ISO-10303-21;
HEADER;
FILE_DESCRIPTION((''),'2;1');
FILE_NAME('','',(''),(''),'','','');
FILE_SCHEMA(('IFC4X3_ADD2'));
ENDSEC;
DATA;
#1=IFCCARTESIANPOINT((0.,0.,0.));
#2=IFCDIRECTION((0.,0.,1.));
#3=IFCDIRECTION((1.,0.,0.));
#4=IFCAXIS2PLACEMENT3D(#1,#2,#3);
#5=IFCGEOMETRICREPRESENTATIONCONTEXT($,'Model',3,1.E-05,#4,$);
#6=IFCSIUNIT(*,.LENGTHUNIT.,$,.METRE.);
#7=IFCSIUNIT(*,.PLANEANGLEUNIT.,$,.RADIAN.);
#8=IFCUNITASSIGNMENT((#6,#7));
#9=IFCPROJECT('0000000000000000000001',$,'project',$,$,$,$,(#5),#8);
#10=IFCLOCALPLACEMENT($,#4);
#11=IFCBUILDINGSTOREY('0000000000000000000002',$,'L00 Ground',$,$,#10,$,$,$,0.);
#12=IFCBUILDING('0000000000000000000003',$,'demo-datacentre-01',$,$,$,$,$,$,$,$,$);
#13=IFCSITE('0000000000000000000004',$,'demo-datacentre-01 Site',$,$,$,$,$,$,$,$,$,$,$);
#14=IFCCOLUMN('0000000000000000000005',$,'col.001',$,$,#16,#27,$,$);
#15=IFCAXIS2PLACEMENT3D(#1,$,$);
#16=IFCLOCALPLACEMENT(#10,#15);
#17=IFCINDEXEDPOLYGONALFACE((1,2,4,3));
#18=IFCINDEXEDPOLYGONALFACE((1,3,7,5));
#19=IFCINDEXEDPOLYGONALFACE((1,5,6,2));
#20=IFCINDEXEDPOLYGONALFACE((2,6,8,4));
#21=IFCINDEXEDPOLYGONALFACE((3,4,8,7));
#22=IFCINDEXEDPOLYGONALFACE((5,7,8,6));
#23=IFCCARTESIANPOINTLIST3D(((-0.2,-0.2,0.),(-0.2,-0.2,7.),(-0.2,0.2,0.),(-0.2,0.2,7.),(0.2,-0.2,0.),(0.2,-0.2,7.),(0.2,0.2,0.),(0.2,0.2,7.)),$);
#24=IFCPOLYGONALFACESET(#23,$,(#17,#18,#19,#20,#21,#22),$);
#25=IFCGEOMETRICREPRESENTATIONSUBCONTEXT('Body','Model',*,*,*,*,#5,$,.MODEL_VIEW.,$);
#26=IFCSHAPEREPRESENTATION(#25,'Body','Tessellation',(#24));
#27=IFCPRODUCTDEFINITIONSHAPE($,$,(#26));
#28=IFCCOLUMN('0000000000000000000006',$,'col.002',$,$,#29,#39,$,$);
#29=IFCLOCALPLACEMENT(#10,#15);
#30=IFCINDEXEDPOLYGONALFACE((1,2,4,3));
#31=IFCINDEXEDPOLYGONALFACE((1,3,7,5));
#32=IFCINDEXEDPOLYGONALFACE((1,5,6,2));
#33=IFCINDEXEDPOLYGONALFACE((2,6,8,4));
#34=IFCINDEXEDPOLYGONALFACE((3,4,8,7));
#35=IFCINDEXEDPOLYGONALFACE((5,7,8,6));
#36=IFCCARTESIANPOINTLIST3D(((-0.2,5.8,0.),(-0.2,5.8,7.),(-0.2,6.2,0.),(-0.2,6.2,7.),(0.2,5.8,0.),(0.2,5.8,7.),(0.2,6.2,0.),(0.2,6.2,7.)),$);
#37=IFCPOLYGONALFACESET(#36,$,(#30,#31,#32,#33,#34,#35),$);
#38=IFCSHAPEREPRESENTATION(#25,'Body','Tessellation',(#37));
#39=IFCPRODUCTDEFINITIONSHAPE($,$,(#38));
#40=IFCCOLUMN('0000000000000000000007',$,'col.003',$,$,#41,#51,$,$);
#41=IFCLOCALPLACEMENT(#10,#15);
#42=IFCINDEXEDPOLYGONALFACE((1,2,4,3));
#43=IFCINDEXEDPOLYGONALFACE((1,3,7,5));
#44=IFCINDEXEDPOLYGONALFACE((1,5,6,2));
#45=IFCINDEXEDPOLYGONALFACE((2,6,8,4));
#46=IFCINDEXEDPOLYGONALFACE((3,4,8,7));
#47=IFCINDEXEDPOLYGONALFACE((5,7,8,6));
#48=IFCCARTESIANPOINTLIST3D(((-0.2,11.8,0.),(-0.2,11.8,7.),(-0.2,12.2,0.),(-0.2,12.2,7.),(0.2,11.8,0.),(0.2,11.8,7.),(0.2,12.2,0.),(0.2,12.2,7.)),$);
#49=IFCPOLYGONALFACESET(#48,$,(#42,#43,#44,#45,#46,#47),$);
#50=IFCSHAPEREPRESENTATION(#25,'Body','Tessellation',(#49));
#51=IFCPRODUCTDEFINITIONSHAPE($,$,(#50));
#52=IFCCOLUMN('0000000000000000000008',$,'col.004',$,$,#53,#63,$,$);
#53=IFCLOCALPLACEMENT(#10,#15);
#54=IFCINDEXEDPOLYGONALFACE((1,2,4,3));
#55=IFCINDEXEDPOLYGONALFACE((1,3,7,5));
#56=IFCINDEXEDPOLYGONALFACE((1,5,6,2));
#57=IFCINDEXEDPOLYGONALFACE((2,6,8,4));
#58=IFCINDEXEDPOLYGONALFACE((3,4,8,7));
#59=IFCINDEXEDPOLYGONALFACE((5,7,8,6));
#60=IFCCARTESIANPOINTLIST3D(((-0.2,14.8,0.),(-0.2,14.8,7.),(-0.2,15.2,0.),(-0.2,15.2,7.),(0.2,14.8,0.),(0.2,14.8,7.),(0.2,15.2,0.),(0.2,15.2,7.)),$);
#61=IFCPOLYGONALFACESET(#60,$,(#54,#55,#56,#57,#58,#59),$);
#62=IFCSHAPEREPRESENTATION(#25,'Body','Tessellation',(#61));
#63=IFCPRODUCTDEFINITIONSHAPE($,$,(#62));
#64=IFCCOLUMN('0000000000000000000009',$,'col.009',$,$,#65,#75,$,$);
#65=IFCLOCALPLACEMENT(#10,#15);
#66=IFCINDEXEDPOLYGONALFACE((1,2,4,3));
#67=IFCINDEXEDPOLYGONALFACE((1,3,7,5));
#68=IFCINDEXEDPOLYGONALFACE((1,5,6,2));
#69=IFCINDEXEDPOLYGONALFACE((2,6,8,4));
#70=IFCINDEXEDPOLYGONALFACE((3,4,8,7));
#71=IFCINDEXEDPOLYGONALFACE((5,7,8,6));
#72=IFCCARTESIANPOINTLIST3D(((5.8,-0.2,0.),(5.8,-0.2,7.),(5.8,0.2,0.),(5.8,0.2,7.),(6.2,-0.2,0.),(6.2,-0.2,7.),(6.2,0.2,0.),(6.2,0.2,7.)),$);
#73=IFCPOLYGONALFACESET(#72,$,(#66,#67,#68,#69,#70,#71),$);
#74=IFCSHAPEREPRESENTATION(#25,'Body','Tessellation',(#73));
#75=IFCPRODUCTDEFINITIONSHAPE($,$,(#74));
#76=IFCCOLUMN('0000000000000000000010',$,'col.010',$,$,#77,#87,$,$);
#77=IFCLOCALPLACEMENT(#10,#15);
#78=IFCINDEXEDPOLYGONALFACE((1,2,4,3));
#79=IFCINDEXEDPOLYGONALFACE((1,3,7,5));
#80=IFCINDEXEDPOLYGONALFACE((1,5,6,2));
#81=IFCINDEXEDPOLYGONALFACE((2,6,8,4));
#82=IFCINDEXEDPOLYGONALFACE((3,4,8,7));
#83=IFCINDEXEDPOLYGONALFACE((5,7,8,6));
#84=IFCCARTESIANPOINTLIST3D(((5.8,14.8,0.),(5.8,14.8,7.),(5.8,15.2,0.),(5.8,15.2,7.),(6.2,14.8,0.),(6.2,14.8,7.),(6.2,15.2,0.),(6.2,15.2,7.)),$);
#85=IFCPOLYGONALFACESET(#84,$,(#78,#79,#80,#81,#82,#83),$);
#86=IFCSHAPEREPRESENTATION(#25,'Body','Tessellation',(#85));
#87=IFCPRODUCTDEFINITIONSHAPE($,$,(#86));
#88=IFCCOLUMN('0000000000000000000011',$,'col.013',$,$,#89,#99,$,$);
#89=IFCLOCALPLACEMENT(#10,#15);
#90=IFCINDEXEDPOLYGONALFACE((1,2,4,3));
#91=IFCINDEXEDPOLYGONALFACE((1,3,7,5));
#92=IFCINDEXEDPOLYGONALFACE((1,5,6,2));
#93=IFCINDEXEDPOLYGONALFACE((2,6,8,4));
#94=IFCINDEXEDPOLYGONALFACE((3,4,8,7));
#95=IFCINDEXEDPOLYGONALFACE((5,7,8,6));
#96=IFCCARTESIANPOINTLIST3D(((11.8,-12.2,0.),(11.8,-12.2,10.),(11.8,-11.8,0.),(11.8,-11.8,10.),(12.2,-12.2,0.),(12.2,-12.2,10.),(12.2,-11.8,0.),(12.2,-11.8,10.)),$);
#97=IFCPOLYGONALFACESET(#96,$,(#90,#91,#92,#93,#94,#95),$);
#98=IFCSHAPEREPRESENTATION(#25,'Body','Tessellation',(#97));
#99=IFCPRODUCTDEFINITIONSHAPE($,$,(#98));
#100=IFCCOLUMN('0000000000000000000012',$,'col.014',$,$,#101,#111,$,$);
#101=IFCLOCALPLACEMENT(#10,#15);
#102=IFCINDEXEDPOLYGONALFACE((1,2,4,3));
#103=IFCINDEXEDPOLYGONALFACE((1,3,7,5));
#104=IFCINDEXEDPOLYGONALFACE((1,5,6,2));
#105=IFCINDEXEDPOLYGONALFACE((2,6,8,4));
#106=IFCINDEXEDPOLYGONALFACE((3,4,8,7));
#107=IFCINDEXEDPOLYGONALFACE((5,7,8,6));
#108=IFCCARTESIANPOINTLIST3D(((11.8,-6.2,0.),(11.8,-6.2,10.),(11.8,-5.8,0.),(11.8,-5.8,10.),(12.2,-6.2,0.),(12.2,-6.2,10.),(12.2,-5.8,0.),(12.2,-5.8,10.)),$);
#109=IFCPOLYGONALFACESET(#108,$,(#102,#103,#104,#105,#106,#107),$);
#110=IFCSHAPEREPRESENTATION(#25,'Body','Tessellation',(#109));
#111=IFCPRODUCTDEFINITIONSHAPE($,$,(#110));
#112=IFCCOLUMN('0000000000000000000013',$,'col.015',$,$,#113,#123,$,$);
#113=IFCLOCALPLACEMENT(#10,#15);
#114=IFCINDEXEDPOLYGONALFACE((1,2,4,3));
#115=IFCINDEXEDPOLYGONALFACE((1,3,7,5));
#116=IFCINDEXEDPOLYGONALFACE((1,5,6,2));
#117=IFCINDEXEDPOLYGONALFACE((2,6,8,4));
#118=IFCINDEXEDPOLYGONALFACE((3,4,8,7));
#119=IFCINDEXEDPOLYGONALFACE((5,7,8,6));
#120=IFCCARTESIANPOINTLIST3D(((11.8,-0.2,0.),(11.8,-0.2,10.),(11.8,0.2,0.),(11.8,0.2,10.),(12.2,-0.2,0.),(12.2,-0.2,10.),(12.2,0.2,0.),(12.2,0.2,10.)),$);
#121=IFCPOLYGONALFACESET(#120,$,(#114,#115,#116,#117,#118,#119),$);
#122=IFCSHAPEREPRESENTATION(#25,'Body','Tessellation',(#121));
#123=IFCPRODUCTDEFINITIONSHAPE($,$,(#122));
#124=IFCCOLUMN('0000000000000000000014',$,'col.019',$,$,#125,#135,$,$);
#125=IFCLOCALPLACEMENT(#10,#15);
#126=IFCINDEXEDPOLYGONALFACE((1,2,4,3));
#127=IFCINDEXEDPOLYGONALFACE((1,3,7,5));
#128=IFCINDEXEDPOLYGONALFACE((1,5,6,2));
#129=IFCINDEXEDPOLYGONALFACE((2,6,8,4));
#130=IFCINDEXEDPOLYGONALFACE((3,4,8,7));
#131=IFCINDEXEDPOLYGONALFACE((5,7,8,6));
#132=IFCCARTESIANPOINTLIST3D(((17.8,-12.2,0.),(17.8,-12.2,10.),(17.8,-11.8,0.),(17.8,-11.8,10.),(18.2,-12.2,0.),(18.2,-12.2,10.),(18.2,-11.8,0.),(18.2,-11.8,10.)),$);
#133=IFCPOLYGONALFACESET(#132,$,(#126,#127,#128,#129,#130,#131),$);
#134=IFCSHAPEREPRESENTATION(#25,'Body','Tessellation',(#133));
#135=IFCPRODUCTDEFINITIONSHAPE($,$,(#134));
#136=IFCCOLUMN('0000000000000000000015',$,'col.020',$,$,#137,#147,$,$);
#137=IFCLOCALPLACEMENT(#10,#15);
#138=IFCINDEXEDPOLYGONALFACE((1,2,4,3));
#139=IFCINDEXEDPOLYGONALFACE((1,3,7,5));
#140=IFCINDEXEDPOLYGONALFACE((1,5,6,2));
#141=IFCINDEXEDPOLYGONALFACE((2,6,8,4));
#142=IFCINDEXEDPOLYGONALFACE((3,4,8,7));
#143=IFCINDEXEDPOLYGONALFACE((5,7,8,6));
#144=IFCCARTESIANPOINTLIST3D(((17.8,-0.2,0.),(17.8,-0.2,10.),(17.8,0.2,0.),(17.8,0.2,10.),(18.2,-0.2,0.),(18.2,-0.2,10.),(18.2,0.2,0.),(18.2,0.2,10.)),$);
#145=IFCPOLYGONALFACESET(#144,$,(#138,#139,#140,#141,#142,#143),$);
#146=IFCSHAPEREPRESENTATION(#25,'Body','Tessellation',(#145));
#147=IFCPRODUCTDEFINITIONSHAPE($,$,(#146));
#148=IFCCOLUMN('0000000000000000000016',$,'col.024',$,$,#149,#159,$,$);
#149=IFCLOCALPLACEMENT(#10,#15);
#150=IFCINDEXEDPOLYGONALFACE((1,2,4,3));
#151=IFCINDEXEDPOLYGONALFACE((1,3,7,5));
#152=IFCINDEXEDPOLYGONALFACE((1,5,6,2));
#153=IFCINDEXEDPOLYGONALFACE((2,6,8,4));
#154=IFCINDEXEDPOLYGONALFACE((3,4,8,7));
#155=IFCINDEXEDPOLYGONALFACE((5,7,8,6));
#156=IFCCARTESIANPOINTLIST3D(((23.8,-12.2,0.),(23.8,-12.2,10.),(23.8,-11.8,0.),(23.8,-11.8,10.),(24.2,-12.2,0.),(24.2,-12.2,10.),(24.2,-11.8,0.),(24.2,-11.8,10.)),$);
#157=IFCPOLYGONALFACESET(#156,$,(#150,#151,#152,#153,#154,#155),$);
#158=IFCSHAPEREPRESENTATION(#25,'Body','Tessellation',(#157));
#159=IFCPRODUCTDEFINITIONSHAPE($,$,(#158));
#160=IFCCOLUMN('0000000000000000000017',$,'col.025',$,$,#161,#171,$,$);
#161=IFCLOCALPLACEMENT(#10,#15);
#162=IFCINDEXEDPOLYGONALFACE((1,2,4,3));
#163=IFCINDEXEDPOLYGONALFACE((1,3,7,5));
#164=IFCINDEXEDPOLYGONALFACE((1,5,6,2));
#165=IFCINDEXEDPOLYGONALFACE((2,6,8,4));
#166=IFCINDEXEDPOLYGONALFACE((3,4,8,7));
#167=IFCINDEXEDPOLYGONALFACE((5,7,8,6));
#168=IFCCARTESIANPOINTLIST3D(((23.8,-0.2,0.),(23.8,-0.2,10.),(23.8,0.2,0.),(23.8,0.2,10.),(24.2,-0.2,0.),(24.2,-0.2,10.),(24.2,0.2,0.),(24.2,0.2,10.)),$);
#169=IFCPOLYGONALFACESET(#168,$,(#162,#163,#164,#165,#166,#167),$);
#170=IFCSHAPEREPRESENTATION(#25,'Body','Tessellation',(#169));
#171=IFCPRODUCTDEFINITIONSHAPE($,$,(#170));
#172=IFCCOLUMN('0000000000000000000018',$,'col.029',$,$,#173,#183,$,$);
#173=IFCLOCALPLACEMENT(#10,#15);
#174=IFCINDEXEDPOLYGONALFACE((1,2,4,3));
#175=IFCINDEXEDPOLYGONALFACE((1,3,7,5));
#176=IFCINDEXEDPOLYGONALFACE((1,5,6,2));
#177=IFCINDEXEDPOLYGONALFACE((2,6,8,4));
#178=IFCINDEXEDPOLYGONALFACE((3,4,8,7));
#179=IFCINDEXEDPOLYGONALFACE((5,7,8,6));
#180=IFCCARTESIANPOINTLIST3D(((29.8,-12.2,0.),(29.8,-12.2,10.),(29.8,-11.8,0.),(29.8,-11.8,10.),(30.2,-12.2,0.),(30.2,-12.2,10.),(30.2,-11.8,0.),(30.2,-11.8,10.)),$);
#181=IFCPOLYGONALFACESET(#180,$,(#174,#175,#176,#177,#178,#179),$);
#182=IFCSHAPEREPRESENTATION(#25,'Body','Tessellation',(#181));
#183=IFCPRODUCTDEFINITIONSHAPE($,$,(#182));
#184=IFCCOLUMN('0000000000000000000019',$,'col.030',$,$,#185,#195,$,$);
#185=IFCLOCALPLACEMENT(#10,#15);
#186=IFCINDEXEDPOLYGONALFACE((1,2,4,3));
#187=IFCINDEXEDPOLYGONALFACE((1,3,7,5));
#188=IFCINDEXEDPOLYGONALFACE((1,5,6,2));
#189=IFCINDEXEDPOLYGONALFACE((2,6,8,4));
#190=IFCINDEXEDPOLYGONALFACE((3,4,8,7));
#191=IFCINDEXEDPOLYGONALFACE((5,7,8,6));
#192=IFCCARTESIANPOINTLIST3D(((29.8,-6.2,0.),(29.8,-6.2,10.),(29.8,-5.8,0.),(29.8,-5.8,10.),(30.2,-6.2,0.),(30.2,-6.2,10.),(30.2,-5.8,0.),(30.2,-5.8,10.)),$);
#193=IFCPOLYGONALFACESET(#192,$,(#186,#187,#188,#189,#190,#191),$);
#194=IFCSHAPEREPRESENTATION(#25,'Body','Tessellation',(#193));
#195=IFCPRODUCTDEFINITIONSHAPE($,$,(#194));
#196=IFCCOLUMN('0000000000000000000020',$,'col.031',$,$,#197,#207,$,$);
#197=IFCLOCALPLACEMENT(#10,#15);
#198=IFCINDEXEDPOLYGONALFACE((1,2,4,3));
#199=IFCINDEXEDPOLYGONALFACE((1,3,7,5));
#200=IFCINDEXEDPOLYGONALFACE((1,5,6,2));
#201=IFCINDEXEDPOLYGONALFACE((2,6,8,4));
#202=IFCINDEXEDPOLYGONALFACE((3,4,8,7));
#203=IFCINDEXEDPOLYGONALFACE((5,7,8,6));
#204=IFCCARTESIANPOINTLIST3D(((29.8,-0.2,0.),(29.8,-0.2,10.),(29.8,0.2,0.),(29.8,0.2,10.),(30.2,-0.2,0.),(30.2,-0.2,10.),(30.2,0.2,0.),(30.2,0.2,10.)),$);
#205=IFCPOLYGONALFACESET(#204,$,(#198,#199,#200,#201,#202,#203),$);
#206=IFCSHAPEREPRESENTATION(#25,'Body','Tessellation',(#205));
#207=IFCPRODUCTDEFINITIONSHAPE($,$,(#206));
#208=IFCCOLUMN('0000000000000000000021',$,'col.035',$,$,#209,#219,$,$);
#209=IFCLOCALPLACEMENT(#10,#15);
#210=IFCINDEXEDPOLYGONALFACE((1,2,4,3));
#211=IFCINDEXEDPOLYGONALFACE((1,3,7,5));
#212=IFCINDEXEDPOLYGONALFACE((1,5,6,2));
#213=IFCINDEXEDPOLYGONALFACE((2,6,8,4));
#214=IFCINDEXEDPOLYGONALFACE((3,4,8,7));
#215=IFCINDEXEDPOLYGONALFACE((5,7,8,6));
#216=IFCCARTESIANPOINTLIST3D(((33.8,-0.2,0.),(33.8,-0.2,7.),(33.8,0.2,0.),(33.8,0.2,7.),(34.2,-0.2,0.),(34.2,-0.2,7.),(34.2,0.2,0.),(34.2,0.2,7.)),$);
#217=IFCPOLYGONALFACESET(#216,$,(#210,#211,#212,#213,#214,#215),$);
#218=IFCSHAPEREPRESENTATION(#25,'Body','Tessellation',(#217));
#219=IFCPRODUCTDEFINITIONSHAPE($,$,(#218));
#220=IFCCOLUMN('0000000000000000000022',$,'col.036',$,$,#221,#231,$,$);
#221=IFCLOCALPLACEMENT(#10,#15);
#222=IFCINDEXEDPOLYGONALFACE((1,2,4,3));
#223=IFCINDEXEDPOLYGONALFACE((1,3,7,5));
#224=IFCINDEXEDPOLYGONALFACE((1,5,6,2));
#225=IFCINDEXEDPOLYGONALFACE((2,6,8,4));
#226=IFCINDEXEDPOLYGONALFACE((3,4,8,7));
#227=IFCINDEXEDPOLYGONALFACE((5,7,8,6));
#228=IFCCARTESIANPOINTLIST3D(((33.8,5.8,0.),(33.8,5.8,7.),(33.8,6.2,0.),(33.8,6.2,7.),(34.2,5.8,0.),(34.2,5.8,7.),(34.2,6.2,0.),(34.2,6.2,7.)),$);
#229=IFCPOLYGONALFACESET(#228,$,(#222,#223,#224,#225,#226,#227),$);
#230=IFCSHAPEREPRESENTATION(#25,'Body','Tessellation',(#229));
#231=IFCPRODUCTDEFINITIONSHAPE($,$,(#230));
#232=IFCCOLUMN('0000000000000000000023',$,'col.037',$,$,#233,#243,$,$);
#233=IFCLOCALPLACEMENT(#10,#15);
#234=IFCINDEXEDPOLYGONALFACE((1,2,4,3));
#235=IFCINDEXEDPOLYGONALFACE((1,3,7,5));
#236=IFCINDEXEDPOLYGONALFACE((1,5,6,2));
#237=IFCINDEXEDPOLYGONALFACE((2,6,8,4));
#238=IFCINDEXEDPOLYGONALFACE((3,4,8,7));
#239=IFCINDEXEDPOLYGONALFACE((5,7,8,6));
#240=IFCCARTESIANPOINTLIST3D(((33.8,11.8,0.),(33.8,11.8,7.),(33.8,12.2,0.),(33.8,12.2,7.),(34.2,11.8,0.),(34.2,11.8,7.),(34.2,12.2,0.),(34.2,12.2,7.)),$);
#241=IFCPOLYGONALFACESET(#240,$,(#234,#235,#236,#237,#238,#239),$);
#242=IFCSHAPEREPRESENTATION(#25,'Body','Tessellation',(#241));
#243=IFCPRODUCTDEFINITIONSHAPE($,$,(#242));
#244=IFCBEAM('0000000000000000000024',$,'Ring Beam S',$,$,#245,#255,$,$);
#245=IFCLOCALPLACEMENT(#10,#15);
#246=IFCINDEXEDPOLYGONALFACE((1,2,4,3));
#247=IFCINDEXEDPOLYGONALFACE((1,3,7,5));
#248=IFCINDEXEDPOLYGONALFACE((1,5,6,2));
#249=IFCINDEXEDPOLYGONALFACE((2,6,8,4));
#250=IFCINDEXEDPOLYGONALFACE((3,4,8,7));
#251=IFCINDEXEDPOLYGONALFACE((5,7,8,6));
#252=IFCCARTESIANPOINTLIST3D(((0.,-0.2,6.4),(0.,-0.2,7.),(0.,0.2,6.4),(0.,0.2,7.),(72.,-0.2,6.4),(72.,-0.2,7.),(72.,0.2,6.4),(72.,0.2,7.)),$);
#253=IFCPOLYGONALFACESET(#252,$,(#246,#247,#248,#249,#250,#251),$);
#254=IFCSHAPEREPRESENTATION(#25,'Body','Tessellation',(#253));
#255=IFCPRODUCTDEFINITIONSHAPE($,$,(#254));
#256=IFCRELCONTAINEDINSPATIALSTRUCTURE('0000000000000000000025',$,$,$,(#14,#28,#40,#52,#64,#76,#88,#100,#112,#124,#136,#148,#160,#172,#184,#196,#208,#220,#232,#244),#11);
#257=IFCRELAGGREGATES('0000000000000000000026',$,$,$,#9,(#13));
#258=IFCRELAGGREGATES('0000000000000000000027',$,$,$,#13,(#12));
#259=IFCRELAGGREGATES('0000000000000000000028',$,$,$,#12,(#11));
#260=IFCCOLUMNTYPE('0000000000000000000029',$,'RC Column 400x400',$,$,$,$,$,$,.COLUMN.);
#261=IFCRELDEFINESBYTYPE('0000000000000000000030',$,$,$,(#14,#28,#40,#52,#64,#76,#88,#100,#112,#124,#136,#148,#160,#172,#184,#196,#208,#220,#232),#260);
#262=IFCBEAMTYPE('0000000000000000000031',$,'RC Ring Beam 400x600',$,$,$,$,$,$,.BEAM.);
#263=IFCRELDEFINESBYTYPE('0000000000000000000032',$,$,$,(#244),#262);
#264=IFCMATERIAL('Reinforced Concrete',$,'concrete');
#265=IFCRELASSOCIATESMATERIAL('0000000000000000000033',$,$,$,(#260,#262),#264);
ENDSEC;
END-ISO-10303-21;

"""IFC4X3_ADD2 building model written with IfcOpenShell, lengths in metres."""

from ifc_helpers import new_model, si_unit, frame, origin_with_axes, place, context, subcontext, project, spatial, rectangle, extrude, material, type_object, element, save


model = new_model("IFC4X3_ADD2")

# Units and contexts
model_context = context("Model", 3, precision=1e-05, world=origin_with_axes())
body_context = subcontext(model_context, "Body", "Model", "MODEL_VIEW")
ifc_project = project(units=[si_unit("LENGTHUNIT", "METRE"), si_unit("PLANEANGLEUNIT", "RADIAN")], contexts=[model_context])

# Site, building, storey
site = spatial("IfcSite", under=ifc_project, Name="demo-datacentre-01 Site")
building = spatial("IfcBuilding", under=site, Name="demo-datacentre-01")
storey_placement = place(None, origin_with_axes())
storey = spatial("IfcBuildingStorey", under=building, at=storey_placement, Name="L00 Ground", Elevation=0.0)

# Columns
ifc_material = material(Name="Reinforced Concrete", Category="concrete")
column_type = type_object("IfcColumnType", Name="RC Column 400x400", PredefinedType="COLUMN", material=ifc_material)
for number, where, z_axis, x_axis, name in (
    (1, (0.0, 0.0, 0.0), (0.0, 0.0, 1.0), (1.0, 0.0, 0.0), "col.001"),
    (2, (0.0, 6.0, 0.0), (0.0, 0.0, 1.0), (1.0, 0.0, 0.0), "col.002"),
    (3, (0.0, 12.0, 0.0), (0.0, 0.0, 1.0), (1.0, 0.0, 0.0), "col.003"),
    (4, (0.0, 15.0, 0.0), (0.0, 0.0, 1.0), (1.0, 0.0, 0.0), "col.004"),
    (5, (6.0, 0.0, 0.0), (0.0, 0.0, 1.0), (1.0, 0.0, 0.0), "col.009"),
    (6, (6.0, 15.0, 0.0), (0.0, 0.0, 1.0), (1.0, 0.0, 0.0), "col.010"),
):
    element("IfcColumn", number, at=place(storey_placement, frame(where, z_axis=z_axis, x_axis=x_axis)), inside=storey, type_object=column_type, Name=name, context=body_context, shape_type="SweptSolid", body=[
        extrude(rectangle(XDim=0.4, YDim=0.4), origin_with_axes(), (0.0, 0.0, 1.0), 7.0),
    ])
for number, where, z_axis, x_axis, name in (
    (7, (12.0, -12.0, 0.0), (0.0, 0.0, 1.0), (1.0, 0.0, 0.0), "col.013"),
    (8, (12.0, -6.0, 0.0), (0.0, 0.0, 1.0), (1.0, 0.0, 0.0), "col.014"),
    (9, (12.0, 0.0, 0.0), (0.0, 0.0, 1.0), (1.0, 0.0, 0.0), "col.015"),
    (10, (18.0, -12.0, 0.0), (0.0, 0.0, 1.0), (1.0, 0.0, 0.0), "col.019"),
    (11, (18.0, 0.0, 0.0), (0.0, 0.0, 1.0), (1.0, 0.0, 0.0), "col.020"),
    (12, (24.0, -12.0, 0.0), (0.0, 0.0, 1.0), (1.0, 0.0, 0.0), "col.024"),
    (13, (24.0, 0.0, 0.0), (0.0, 0.0, 1.0), (1.0, 0.0, 0.0), "col.025"),
    (14, (30.0, -12.0, 0.0), (0.0, 0.0, 1.0), (1.0, 0.0, 0.0), "col.029"),
    (15, (30.0, -6.0, 0.0), (0.0, 0.0, 1.0), (1.0, 0.0, 0.0), "col.030"),
    (16, (30.0, 0.0, 0.0), (0.0, 0.0, 1.0), (1.0, 0.0, 0.0), "col.031"),
):
    element("IfcColumn", number, at=place(storey_placement, frame(where, z_axis=z_axis, x_axis=x_axis)), inside=storey, type_object=column_type, Name=name, context=body_context, shape_type="SweptSolid", body=[
        extrude(rectangle(XDim=0.4, YDim=0.4), origin_with_axes(), (0.0, 0.0, 1.0), 10.0),
    ])
for number, where, z_axis, x_axis, name in (
    (17, (34.0, 0.0, 0.0), (0.0, 0.0, 1.0), (1.0, 0.0, 0.0), "col.035"),
    (18, (34.0, 6.0, 0.0), (0.0, 0.0, 1.0), (1.0, 0.0, 0.0), "col.036"),
    (19, (34.0, 12.0, 0.0), (0.0, 0.0, 1.0), (1.0, 0.0, 0.0), "col.037"),
):
    element("IfcColumn", number, at=place(storey_placement, frame(where, z_axis=z_axis, x_axis=x_axis)), inside=storey, type_object=column_type, Name=name, context=body_context, shape_type="SweptSolid", body=[
        extrude(rectangle(XDim=0.4, YDim=0.4), origin_with_axes(), (0.0, 0.0, 1.0), 7.0),
    ])

# Beam
beam_type = type_object("IfcBeamType", Name="RC Ring Beam 400x600", PredefinedType="BEAM", material=ifc_material)
beam_1_placement = place(storey_placement, frame((0.0, 0.0, 6.7), z_axis=(1.0, 0.0, 0.0), x_axis=(0.0, 1.0, 0.0)))
element("IfcBeam", 20, at=beam_1_placement, inside=storey, type_object=beam_type, Name="Ring Beam S", context=body_context, shape_type="SweptSolid", body=[
    extrude(rectangle(XDim=0.4, YDim=0.6), origin_with_axes(), (0.0, 0.0, 1.0), 72.0),
])

save(model, "model.ifc")
